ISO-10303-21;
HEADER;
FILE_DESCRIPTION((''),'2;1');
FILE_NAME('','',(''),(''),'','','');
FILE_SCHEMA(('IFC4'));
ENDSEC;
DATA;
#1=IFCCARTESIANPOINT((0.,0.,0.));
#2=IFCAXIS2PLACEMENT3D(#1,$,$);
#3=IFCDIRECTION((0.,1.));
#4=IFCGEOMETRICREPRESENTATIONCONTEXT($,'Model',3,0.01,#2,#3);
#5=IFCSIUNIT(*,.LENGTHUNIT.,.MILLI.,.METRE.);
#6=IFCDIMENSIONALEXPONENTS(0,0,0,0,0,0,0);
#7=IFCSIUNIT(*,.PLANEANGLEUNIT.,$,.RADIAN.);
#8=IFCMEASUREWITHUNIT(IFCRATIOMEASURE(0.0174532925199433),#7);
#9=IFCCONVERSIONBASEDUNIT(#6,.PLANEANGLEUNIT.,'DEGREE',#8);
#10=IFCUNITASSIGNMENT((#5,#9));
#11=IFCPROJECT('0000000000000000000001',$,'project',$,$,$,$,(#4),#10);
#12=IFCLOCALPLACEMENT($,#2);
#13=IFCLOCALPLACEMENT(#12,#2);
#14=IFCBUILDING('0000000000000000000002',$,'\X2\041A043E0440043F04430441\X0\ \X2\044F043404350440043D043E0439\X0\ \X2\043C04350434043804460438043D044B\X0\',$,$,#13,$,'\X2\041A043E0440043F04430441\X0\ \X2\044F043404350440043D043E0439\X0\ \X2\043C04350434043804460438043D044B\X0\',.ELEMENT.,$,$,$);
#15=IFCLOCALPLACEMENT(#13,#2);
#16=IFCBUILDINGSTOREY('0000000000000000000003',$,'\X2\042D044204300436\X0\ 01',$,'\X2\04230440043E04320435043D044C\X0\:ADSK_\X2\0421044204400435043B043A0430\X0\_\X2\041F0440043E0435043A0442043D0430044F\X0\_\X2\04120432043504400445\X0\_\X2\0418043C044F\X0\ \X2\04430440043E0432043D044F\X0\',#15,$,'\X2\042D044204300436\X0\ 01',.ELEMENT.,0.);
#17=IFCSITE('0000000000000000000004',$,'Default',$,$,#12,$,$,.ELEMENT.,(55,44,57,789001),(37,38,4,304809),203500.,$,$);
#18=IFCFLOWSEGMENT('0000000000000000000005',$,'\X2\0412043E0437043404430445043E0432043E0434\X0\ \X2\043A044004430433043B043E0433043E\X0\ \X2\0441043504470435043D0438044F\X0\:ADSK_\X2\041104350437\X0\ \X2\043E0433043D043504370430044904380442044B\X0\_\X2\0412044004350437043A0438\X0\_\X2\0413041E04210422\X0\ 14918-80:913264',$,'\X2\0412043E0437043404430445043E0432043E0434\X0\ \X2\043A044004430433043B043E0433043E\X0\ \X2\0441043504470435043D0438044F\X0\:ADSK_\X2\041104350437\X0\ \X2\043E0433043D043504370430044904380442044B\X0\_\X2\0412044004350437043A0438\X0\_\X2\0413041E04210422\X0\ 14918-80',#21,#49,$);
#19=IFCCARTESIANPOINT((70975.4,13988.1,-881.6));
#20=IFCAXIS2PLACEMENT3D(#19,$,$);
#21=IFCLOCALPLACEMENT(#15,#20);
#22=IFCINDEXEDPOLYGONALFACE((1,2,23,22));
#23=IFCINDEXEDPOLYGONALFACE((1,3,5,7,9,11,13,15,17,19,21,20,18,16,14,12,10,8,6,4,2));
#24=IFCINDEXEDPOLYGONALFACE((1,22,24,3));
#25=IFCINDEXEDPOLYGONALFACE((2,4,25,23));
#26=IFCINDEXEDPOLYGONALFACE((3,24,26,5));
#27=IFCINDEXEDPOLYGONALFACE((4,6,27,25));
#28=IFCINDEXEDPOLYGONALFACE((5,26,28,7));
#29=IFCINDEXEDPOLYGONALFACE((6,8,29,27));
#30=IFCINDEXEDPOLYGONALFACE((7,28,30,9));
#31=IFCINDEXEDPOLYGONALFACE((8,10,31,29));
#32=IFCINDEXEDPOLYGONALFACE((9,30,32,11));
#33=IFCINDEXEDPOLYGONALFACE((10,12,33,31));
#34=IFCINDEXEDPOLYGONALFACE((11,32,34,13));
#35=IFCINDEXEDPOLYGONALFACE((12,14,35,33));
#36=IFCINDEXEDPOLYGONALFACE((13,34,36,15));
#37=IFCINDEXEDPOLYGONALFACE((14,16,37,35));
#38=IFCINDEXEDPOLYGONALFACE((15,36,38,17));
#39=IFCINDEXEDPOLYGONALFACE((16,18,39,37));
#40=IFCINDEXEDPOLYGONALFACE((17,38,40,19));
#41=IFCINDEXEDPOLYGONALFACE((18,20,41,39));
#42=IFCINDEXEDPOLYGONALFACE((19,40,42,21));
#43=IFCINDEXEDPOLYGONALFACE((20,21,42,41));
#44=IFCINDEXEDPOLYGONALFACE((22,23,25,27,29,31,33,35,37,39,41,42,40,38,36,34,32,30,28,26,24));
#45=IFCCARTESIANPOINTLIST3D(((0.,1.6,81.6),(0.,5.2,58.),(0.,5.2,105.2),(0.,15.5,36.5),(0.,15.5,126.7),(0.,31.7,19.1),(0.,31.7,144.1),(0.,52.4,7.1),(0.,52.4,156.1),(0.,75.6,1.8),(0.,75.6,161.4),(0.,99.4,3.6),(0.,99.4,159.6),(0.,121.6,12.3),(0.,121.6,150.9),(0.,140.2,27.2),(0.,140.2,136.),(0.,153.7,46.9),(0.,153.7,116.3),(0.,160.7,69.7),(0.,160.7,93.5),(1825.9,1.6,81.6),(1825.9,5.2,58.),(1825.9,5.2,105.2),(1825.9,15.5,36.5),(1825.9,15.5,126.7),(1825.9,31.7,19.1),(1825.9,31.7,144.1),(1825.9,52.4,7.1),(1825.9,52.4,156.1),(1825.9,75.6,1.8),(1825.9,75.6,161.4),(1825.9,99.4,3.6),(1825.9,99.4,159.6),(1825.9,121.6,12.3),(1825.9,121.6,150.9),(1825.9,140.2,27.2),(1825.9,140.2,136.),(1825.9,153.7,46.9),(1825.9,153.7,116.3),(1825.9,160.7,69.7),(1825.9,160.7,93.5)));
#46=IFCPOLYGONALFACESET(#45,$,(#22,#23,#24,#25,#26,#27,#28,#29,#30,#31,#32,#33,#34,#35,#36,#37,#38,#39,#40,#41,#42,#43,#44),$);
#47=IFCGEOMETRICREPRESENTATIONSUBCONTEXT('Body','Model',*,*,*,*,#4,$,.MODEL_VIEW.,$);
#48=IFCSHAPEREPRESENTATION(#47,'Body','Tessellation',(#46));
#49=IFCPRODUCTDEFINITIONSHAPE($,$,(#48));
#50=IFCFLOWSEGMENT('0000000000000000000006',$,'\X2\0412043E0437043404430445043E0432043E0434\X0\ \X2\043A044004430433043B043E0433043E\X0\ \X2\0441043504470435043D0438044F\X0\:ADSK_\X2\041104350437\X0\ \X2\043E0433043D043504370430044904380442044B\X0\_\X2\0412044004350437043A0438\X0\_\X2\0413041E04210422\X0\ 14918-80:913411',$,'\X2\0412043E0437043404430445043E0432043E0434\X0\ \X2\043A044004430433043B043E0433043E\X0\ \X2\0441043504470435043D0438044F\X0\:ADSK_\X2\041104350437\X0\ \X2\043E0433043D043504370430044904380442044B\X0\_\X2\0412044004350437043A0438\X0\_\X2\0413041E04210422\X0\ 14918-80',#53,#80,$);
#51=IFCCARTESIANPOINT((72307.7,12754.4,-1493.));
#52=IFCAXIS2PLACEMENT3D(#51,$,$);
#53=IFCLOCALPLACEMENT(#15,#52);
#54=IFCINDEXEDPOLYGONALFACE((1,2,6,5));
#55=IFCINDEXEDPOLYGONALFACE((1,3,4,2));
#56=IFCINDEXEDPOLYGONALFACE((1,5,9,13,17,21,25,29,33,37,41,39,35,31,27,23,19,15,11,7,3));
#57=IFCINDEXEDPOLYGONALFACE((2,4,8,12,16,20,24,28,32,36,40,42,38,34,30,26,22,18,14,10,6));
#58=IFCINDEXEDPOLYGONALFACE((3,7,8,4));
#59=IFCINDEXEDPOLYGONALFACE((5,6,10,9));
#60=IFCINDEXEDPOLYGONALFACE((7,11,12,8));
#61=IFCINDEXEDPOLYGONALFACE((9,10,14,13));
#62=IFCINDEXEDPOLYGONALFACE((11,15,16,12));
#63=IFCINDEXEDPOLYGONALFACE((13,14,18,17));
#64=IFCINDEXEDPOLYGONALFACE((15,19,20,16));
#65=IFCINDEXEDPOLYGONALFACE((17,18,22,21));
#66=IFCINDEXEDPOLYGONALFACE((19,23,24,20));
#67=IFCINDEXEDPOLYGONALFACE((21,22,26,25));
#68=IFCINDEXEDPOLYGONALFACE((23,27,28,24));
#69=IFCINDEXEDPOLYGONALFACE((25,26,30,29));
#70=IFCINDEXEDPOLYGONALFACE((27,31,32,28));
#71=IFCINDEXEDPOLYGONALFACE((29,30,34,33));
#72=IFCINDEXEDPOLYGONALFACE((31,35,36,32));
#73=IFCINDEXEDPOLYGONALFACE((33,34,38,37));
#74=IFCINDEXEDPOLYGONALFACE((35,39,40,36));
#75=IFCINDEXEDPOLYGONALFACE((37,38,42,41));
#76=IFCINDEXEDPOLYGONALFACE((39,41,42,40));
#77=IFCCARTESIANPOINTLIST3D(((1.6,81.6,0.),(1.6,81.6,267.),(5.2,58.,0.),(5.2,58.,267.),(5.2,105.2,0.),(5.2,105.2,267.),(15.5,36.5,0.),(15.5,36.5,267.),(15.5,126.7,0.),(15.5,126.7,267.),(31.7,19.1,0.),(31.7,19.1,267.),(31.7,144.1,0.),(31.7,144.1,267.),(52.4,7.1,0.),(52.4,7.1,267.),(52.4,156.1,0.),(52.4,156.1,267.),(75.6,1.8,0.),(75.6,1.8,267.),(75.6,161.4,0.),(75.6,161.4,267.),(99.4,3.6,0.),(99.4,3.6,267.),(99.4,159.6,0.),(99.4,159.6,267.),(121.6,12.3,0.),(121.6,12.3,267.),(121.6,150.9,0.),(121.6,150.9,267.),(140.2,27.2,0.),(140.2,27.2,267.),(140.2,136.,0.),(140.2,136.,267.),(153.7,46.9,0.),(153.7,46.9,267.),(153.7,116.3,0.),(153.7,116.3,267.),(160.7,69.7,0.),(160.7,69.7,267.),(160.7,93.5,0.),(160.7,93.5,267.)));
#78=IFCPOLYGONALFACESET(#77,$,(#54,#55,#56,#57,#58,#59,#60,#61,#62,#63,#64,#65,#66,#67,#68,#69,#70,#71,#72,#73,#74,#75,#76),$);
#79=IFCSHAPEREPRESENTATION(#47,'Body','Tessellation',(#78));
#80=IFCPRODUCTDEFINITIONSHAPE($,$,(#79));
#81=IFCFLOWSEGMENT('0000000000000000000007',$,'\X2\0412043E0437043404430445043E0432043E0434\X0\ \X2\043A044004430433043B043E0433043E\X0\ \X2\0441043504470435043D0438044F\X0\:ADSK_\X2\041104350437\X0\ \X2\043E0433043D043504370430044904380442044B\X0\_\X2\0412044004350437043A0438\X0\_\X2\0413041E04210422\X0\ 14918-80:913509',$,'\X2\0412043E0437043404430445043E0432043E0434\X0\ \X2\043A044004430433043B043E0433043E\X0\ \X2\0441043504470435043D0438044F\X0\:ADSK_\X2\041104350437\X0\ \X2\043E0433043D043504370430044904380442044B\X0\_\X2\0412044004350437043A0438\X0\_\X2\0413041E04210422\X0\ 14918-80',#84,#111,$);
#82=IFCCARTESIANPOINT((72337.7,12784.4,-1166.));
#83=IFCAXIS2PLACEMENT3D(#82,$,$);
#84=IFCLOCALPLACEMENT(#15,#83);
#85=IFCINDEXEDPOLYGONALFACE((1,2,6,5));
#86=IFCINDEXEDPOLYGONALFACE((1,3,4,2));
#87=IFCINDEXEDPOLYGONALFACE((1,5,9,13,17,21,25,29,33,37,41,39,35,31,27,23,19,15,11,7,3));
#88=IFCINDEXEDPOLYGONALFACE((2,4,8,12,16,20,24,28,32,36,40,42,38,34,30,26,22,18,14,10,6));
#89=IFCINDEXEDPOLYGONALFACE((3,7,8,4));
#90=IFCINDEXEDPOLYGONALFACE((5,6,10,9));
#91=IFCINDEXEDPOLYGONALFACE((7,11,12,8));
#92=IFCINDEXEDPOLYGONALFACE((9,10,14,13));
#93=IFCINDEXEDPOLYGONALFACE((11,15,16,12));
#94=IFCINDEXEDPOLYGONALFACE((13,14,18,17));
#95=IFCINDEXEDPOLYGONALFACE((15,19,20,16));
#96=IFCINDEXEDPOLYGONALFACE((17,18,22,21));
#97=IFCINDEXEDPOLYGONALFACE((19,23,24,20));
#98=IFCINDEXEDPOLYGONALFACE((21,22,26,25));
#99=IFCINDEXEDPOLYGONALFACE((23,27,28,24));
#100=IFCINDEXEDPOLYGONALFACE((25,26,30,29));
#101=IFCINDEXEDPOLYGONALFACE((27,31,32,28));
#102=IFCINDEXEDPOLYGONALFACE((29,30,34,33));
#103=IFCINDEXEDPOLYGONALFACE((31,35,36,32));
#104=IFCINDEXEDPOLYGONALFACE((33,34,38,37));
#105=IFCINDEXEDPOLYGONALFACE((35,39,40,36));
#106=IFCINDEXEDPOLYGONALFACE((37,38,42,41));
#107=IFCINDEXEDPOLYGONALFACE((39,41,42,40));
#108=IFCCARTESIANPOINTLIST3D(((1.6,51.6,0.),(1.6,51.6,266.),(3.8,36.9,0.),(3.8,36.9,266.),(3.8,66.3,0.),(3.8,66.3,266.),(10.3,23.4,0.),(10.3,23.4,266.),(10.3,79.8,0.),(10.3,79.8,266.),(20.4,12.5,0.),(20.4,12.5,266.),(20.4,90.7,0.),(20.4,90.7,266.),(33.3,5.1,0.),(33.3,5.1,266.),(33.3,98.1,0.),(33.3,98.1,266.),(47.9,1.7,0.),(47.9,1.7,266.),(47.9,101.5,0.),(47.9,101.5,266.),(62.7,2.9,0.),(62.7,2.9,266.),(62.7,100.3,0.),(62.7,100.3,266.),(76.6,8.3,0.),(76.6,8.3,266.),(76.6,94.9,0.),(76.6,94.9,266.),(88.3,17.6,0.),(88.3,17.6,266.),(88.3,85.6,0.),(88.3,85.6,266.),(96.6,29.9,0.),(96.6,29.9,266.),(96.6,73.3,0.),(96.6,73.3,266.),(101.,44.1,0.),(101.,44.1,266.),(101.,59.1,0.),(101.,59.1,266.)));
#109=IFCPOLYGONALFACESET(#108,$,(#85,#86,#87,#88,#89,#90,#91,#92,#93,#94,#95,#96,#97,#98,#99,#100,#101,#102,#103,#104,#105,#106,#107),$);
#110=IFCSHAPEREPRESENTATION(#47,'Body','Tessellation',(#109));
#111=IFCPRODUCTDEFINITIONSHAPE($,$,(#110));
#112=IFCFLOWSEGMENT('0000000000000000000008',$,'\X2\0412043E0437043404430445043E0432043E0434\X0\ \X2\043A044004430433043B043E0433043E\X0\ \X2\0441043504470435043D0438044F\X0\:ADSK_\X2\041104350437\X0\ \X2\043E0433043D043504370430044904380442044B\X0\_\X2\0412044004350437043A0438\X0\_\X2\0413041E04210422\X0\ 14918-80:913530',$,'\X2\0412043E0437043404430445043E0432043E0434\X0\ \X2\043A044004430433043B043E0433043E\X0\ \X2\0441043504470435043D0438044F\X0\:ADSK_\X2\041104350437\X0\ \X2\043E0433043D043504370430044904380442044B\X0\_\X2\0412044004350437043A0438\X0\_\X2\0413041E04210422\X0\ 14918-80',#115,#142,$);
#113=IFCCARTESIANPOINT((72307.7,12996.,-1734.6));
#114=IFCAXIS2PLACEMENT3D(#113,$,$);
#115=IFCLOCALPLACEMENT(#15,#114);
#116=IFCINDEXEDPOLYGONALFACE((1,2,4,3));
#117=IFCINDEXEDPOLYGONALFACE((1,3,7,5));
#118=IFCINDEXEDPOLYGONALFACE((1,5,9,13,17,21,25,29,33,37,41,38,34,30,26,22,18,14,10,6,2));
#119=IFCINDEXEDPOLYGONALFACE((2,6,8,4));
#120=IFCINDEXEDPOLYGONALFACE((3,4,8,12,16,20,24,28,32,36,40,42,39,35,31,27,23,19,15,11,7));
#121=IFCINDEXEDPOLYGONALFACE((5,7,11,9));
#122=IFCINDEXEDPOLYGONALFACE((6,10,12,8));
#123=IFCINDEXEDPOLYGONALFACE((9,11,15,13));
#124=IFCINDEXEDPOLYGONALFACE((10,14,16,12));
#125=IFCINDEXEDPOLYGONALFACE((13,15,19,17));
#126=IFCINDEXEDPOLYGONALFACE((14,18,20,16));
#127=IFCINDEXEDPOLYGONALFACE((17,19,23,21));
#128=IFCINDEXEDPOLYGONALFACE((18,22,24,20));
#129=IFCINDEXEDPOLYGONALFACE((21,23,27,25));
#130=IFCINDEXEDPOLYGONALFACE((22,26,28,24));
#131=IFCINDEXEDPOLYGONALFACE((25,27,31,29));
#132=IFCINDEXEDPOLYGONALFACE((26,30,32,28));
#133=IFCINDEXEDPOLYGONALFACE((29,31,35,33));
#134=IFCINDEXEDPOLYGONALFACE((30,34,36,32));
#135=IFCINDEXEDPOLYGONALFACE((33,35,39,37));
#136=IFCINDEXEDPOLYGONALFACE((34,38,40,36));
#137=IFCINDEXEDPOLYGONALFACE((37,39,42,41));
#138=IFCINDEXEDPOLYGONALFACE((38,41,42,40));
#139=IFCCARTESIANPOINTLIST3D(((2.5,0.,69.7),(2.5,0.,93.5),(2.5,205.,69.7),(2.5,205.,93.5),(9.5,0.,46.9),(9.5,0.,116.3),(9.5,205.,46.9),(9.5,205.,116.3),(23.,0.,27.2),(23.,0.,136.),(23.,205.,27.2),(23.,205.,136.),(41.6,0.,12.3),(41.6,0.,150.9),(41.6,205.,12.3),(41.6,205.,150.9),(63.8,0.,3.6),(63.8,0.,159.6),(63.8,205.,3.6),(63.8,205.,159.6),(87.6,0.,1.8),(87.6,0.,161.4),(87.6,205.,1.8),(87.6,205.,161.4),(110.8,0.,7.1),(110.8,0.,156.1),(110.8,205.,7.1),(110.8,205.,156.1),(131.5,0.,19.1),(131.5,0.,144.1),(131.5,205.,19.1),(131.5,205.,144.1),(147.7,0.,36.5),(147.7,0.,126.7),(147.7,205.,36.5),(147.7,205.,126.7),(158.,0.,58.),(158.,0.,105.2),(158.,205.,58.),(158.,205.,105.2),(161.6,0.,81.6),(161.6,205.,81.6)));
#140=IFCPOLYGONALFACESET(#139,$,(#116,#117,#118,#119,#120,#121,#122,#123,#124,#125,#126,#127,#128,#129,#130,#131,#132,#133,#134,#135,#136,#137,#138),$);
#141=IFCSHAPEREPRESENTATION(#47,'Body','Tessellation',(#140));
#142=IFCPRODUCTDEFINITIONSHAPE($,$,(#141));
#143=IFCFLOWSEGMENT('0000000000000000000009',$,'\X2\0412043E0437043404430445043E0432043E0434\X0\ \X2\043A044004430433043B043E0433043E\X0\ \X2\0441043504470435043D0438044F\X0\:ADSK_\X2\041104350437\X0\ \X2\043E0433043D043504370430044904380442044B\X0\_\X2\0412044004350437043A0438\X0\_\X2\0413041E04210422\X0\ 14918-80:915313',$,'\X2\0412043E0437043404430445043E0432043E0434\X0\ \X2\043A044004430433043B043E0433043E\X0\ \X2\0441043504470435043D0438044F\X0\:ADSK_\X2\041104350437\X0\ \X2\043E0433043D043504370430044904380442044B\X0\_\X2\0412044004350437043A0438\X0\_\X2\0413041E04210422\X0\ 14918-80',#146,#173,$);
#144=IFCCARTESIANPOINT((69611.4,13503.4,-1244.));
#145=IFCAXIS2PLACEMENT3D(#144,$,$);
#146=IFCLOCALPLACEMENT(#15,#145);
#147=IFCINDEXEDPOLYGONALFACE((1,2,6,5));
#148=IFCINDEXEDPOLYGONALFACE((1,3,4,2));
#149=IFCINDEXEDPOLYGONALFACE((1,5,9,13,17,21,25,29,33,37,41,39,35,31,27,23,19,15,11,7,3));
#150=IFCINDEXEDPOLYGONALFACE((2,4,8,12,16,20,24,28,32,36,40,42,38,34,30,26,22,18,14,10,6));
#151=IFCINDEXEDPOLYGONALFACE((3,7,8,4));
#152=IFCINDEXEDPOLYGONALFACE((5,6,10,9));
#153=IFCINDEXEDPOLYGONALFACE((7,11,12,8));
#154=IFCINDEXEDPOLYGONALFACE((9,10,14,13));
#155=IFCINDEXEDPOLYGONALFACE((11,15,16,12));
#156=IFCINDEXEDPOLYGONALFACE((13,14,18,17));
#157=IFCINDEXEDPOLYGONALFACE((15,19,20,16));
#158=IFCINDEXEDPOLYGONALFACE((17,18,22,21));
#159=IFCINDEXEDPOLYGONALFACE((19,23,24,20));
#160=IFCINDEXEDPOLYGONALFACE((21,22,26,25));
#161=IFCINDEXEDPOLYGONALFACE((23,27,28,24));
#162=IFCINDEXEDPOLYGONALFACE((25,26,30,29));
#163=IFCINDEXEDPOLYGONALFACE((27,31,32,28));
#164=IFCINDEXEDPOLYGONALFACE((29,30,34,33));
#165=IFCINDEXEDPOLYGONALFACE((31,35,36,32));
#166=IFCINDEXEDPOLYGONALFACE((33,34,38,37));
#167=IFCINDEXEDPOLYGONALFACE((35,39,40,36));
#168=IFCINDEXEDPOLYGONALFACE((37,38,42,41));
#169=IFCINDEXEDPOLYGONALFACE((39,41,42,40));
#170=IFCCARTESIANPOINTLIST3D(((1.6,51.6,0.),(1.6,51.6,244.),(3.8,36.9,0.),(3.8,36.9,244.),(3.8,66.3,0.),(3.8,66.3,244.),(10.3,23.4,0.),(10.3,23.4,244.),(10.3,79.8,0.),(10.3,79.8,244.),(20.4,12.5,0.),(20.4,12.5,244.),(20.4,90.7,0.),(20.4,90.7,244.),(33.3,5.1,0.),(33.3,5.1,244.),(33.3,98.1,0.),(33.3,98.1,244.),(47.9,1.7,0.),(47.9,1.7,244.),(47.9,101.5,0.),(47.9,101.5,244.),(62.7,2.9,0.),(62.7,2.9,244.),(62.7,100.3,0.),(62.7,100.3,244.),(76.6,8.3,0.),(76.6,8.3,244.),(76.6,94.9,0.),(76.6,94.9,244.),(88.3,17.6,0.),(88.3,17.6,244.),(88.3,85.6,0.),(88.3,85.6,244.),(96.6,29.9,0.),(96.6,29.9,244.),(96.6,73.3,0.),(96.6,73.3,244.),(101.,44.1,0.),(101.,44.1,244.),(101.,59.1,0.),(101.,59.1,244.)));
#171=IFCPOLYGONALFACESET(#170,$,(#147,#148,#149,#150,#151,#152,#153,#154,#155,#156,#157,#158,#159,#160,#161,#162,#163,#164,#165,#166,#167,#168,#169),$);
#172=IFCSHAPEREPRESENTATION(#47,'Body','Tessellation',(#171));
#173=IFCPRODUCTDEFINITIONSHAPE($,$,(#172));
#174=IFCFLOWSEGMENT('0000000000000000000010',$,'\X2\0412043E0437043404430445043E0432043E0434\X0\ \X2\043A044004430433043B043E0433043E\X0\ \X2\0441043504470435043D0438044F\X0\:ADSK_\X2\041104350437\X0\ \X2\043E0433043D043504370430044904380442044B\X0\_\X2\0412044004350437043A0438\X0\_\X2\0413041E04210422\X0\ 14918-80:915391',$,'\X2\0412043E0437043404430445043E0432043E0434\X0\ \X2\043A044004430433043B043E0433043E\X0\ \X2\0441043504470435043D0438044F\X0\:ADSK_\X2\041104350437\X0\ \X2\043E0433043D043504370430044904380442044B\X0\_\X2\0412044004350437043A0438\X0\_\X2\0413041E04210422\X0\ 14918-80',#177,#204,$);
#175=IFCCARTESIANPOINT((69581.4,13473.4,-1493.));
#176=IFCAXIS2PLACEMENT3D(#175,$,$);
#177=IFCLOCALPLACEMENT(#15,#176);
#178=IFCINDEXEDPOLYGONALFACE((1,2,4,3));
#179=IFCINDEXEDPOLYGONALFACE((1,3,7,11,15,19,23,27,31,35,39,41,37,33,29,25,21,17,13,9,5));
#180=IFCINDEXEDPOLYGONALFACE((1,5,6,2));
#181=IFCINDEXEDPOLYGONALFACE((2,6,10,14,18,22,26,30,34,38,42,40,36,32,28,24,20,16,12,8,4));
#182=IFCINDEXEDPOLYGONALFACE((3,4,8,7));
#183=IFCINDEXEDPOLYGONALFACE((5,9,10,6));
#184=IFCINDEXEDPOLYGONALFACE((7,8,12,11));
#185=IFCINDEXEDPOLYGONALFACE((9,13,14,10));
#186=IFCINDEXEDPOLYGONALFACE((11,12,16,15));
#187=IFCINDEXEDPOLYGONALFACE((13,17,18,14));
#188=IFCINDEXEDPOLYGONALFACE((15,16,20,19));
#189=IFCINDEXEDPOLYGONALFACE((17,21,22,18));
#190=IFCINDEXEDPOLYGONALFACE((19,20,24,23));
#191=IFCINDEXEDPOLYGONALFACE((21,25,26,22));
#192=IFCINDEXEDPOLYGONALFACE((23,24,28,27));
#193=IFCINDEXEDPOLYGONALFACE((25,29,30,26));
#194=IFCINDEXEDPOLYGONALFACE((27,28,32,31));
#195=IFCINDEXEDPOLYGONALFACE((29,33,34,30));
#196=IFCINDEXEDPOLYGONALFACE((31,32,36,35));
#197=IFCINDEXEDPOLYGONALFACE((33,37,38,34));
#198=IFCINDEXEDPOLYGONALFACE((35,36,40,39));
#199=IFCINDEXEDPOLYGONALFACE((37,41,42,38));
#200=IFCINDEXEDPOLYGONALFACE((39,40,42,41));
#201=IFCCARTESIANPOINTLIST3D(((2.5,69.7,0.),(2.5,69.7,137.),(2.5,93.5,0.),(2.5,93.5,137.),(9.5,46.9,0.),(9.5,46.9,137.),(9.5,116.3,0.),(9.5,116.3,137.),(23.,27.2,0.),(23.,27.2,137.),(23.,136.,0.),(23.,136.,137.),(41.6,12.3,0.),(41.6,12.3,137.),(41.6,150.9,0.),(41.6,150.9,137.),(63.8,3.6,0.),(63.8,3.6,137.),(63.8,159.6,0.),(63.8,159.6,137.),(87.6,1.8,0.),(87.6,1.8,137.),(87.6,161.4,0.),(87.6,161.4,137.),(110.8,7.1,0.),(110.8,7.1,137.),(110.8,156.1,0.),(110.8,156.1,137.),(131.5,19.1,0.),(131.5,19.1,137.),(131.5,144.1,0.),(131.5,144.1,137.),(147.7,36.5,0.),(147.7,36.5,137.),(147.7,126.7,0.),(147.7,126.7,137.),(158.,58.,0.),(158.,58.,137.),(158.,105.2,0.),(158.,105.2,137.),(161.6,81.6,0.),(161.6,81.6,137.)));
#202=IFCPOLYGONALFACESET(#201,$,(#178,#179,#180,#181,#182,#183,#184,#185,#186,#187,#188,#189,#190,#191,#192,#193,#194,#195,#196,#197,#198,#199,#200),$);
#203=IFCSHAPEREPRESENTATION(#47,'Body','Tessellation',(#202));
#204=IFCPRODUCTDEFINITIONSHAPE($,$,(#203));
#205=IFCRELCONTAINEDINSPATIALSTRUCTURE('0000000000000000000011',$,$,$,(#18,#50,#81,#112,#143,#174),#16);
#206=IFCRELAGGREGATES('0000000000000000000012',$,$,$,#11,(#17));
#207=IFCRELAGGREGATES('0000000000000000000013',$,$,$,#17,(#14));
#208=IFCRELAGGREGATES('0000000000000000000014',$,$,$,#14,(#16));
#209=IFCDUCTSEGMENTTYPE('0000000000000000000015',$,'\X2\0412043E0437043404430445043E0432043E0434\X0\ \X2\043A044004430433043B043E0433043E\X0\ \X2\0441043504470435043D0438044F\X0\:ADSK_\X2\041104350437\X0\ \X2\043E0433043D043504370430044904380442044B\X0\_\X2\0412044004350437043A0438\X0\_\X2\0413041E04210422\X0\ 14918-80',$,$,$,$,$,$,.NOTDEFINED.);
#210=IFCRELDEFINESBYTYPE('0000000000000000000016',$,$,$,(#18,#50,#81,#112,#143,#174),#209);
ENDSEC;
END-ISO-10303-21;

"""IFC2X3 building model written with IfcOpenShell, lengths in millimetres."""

from ifc_helpers import new_model, entity, si_unit, converted_unit, direction, frame, origin, origin_2d_with_axis, place, context, subcontext, project, spatial, circle, extrude, type_object, element, save


model = new_model("IFC2X3")

# Units and contexts
model_context = context("Model", 3, precision=0.01, world=origin(), true_north=direction((0.0, 1.0)))
body_context = subcontext(model_context, "Body", "Model", "MODEL_VIEW")
ifc_project = project(units=[si_unit("LENGTHUNIT", "METRE", prefix="MILLI"), converted_unit("PLANEANGLEUNIT", "DEGREE", entity("IfcRatioMeasure", 0.0174532925199433), si_unit("PLANEANGLEUNIT", "RADIAN"), dimensions=[0, 0, 0, 0, 0, 0, 0])], contexts=[model_context])

# Site, building, storey
site_placement = place(None, origin())
site = spatial("IfcSite", under=ifc_project, at=site_placement, Name="Default", CompositionType="ELEMENT", RefLatitude=(55, 44, 57, 789001), RefLongitude=(37, 38, 4, 304809), RefElevation=203500.0)
building_placement = place(site_placement, origin())
building = spatial("IfcBuilding", under=site, at=building_placement, Name="Корпус ядерной медицины", LongName="Корпус ядерной медицины", CompositionType="ELEMENT")
storey_placement = place(building_placement, origin())
storey = spatial("IfcBuildingStorey", under=building, at=storey_placement, Name="Этаж 01", ObjectType="Уровень:ADSK_Стрелка_Проектная_Вверх_Имя уровня", LongName="Этаж 01", CompositionType="ELEMENT", Elevation=0.0)

# Flow segments
duct_segment_type = type_object("IfcDuctSegmentType", Name="Воздуховод круглого сечения:ADSK_Без огнезащиты_Врезки_ГОСТ 14918-80", PredefinedType="NOTDEFINED")
flow_segment_1_placement = place(storey_placement, frame((70975.4, 13988.1, -881.6)))
element("IfcFlowSegment", 1, at=flow_segment_1_placement, inside=storey, type_object=duct_segment_type, Name="Воздуховод круглого сечения:ADSK_Без огнезащиты_Врезки_ГОСТ 14918-80:913264", ObjectType="Воздуховод круглого сечения:ADSK_Без огнезащиты_Врезки_ГОСТ 14918-80", context=body_context, shape_type="SweptSolid", body=[
    extrude(circle(Radius=80.0, at=origin_2d_with_axis()), frame((0.0, 81.6, 81.6), z_axis=(1.0, 0.0, 0.0), x_axis=(0.0, -1.0, 0.0)), (0.0, 0.0, 1.0), 1825.9),
])
flow_segment_2_placement = place(storey_placement, frame((72307.7, 12754.4, -1493.0)))
element("IfcFlowSegment", 2, at=flow_segment_2_placement, inside=storey, type_object=duct_segment_type, Name="Воздуховод круглого сечения:ADSK_Без огнезащиты_Врезки_ГОСТ 14918-80:913411", ObjectType="Воздуховод круглого сечения:ADSK_Без огнезащиты_Врезки_ГОСТ 14918-80", context=body_context, shape_type="SweptSolid", body=[
    extrude(circle(Radius=80.0, at=origin_2d_with_axis()), frame((81.6, 81.6, 0.0), z_axis=(0.0, 0.0, 1.0), x_axis=(-1.0, 0.0, 0.0)), (0.0, 0.0, 1.0), 267.0),
])
flow_segment_3_placement = place(storey_placement, frame((72337.7, 12784.4, -1166.0)))
element("IfcFlowSegment", 3, at=flow_segment_3_placement, inside=storey, type_object=duct_segment_type, Name="Воздуховод круглого сечения:ADSK_Без огнезащиты_Врезки_ГОСТ 14918-80:913509", ObjectType="Воздуховод круглого сечения:ADSK_Без огнезащиты_Врезки_ГОСТ 14918-80", context=body_context, shape_type="SweptSolid", body=[
    extrude(circle(Radius=50.0, at=origin_2d_with_axis()), frame((51.6, 51.6, 0.0), z_axis=(0.0, 0.0, 1.0), x_axis=(-1.0, 0.0, 0.0)), (0.0, 0.0, 1.0), 266.0),
])
flow_segment_4_placement = place(storey_placement, frame((72307.7, 12996.0, -1734.6)))
element("IfcFlowSegment", 4, at=flow_segment_4_placement, inside=storey, type_object=duct_segment_type, Name="Воздуховод круглого сечения:ADSK_Без огнезащиты_Врезки_ГОСТ 14918-80:913530", ObjectType="Воздуховод круглого сечения:ADSK_Без огнезащиты_Врезки_ГОСТ 14918-80", context=body_context, shape_type="SweptSolid", body=[
    extrude(circle(Radius=80.0, at=origin_2d_with_axis()), frame((81.6, 0.0, 81.6), z_axis=(0.0, 1.0, 0.0), x_axis=(1.0, 0.0, 0.0)), (0.0, 0.0, 1.0), 205.0),
])
flow_segment_5_placement = place(storey_placement, frame((69611.4, 13503.4, -1244.0)))
element("IfcFlowSegment", 5, at=flow_segment_5_placement, inside=storey, type_object=duct_segment_type, Name="Воздуховод круглого сечения:ADSK_Без огнезащиты_Врезки_ГОСТ 14918-80:915313", ObjectType="Воздуховод круглого сечения:ADSK_Без огнезащиты_Врезки_ГОСТ 14918-80", context=body_context, shape_type="SweptSolid", body=[
    extrude(circle(Radius=50.0, at=origin_2d_with_axis()), frame((51.6, 51.6, 0.0), z_axis=(0.0, 0.0, 1.0), x_axis=(-1.0, 0.0, 0.0)), (0.0, 0.0, 1.0), 244.0),
])
flow_segment_6_placement = place(storey_placement, frame((69581.4, 13473.4, -1493.0)))
element("IfcFlowSegment", 6, at=flow_segment_6_placement, inside=storey, type_object=duct_segment_type, Name="Воздуховод круглого сечения:ADSK_Без огнезащиты_Врезки_ГОСТ 14918-80:915391", ObjectType="Воздуховод круглого сечения:ADSK_Без огнезащиты_Врезки_ГОСТ 14918-80", context=body_context, shape_type="SweptSolid", body=[
    extrude(circle(Radius=80.0, at=origin_2d_with_axis()), frame((81.6, 81.6, 0.0)), (0.0, 0.0, 1.0), 137.0),
])

save(model, "model.ifc")
